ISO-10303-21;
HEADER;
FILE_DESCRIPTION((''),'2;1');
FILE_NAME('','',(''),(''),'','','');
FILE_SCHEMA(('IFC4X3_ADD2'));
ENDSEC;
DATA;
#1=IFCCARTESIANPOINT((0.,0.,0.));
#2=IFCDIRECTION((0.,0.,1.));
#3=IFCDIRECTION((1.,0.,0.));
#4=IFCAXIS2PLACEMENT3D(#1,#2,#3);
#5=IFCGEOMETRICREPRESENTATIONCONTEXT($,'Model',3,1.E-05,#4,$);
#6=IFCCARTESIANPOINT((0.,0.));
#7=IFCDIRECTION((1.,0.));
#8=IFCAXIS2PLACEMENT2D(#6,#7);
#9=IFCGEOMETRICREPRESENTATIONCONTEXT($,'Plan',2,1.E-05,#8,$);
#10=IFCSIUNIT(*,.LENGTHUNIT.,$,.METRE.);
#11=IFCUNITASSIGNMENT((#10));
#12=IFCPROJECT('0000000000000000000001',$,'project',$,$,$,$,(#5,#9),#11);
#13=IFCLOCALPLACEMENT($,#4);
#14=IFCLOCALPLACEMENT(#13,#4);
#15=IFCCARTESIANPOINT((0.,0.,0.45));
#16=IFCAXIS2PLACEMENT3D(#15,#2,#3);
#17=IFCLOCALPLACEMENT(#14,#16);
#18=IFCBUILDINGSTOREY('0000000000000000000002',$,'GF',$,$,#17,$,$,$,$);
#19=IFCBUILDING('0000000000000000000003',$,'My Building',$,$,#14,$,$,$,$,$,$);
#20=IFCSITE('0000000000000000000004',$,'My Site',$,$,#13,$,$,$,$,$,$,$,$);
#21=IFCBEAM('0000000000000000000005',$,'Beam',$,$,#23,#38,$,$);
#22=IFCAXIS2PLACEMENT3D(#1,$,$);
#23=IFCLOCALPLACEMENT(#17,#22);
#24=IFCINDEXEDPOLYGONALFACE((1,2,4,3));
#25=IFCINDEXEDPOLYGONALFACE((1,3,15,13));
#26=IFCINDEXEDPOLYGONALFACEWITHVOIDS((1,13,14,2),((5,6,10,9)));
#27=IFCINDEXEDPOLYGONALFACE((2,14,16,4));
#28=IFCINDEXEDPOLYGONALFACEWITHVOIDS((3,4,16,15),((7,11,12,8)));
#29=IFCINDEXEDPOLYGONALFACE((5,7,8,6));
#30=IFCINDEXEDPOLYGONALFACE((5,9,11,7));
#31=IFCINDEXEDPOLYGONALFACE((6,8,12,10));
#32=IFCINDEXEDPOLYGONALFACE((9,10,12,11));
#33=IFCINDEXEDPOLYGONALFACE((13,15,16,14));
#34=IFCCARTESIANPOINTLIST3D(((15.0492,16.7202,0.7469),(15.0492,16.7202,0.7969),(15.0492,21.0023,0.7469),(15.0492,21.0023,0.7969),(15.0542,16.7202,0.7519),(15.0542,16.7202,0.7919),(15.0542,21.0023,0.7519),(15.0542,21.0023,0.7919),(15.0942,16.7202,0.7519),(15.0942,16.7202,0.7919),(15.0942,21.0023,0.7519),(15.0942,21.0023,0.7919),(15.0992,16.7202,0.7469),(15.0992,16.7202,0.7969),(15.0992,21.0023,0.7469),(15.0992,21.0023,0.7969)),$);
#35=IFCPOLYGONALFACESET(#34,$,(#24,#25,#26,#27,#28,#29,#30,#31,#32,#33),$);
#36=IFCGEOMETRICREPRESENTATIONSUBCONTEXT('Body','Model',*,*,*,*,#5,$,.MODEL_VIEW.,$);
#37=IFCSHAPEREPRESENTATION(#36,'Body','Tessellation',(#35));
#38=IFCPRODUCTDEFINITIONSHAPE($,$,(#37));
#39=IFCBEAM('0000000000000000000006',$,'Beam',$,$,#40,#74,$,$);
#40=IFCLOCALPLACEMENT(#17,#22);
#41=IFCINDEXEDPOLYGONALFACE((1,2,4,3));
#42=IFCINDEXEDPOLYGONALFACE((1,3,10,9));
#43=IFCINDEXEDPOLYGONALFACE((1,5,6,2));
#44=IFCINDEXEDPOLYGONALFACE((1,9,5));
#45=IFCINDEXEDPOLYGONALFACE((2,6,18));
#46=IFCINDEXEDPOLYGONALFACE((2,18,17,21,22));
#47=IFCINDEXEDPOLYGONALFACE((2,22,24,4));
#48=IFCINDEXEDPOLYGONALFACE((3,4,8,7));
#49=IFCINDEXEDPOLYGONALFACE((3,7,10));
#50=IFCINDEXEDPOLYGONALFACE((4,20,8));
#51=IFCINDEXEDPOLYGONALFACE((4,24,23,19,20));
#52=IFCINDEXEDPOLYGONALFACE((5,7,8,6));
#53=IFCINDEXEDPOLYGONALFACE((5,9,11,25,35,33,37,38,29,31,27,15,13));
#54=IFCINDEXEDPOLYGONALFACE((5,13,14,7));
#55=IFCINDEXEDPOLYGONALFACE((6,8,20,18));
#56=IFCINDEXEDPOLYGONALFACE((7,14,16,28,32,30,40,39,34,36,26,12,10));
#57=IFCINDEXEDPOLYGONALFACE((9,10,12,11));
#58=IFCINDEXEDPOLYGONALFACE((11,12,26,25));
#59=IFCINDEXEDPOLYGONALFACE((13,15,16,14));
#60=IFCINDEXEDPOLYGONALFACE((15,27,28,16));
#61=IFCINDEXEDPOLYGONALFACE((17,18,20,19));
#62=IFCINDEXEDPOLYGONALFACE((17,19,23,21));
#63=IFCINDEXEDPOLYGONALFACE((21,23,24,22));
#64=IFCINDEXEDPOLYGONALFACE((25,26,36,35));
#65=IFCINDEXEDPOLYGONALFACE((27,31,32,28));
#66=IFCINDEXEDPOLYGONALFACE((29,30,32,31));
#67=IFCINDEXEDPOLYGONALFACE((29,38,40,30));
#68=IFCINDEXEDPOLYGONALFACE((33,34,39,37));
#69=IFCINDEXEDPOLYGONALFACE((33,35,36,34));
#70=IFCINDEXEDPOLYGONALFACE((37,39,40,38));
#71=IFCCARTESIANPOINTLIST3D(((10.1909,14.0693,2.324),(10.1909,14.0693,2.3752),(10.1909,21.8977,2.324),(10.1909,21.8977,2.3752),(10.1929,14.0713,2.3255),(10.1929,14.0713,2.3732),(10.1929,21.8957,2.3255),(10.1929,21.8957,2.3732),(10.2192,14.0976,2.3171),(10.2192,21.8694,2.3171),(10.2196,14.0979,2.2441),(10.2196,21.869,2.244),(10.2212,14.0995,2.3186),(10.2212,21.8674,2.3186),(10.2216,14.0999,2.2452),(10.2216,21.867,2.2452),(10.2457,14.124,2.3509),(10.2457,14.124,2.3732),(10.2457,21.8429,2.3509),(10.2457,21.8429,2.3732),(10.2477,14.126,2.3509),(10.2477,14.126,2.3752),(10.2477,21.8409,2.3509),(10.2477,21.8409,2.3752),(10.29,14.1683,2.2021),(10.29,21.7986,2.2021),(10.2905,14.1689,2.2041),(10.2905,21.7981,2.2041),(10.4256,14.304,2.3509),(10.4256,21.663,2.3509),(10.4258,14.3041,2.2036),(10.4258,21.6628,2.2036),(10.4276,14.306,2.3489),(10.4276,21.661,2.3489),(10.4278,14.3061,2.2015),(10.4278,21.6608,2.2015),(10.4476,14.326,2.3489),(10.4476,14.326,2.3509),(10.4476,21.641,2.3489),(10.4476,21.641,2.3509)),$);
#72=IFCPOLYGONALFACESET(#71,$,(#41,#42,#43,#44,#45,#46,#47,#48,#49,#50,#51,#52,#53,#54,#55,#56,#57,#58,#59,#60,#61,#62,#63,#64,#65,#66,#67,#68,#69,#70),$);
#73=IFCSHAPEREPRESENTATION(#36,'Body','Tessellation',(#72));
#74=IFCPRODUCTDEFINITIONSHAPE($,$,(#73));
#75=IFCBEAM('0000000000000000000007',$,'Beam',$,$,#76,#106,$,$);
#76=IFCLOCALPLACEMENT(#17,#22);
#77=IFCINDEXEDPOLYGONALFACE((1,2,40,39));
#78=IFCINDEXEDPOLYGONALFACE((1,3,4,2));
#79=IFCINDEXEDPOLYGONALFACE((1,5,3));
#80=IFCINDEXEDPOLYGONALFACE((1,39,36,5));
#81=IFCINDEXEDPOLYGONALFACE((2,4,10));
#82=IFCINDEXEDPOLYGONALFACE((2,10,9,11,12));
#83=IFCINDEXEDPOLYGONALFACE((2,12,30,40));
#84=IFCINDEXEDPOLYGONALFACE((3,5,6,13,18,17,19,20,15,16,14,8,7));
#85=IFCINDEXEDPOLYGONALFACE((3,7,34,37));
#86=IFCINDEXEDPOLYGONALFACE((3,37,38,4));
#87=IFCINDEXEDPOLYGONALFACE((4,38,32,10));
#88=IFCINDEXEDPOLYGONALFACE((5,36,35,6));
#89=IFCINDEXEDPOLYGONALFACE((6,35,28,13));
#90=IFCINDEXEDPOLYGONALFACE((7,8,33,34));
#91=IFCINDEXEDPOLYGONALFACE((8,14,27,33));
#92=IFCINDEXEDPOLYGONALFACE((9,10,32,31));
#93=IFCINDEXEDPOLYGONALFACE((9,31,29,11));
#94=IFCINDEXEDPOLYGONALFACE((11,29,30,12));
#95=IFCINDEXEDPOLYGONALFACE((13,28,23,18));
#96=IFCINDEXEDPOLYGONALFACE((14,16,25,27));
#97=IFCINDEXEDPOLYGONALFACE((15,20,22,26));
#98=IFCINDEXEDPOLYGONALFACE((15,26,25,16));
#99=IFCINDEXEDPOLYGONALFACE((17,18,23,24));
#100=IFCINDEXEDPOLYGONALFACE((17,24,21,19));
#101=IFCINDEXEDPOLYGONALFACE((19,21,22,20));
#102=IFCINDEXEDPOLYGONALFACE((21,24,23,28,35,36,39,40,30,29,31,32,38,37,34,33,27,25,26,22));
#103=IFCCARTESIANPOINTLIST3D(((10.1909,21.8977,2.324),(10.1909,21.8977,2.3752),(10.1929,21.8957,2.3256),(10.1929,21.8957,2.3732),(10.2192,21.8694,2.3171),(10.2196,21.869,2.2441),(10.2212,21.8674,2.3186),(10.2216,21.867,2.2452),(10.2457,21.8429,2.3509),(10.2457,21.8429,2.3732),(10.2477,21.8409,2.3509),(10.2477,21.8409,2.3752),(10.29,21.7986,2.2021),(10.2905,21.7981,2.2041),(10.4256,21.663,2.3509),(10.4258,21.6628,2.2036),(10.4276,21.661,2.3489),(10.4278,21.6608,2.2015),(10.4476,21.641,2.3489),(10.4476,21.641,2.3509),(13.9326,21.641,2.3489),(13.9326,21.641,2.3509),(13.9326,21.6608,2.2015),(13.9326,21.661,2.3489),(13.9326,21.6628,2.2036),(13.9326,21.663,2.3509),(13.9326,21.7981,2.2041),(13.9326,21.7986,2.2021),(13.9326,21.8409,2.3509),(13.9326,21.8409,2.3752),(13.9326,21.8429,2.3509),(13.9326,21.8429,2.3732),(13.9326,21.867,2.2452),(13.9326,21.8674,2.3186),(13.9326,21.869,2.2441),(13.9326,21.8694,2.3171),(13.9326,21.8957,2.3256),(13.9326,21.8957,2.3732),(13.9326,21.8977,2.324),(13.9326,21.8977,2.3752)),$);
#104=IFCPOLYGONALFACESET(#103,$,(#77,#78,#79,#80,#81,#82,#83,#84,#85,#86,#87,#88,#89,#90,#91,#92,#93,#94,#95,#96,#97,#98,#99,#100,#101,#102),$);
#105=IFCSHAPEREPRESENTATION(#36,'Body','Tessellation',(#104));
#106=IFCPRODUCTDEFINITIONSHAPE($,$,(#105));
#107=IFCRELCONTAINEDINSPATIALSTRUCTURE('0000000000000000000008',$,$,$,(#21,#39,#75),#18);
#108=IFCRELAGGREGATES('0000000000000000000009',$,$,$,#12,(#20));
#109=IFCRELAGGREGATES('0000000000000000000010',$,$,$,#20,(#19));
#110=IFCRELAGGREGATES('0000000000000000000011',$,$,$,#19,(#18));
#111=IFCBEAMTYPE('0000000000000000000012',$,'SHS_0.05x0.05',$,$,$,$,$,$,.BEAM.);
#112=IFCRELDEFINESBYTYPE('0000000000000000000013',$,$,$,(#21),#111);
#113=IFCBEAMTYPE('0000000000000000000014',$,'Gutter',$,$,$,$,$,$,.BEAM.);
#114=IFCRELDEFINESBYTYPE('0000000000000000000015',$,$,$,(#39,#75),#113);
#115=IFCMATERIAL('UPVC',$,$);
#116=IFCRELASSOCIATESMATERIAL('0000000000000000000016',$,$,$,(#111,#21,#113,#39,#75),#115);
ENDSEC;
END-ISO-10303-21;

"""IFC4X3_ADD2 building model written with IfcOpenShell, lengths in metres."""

from ifc_helpers import new_model, si_unit, frame, origin_with_axes, origin_2d_with_axis, place, context, subcontext, project, spatial, indexed_curve, hollow_rectangle, outline, extrude, clip, halfspace, material, material_profile, profile_set, profile_usage, type_object, element, save


model = new_model("IFC4X3_ADD2")

# Units and contexts
model_context = context("Model", 3, precision=1e-05, world=origin_with_axes())
plan_context = context("Plan", 2, precision=1e-05, world=origin_2d_with_axis())
body_context_1 = subcontext(model_context, "Body", "Model", "MODEL_VIEW")
ifc_project = project(units=[si_unit("LENGTHUNIT", "METRE")], contexts=[model_context, plan_context])

# Site, building, storey
site_placement = place(None, origin_with_axes())
site = spatial("IfcSite", under=ifc_project, at=site_placement, Name="My Site")
building_placement = place(site_placement, origin_with_axes())
building = spatial("IfcBuilding", under=site, at=building_placement, Name="My Building")
storey_placement = place(building_placement, frame((0.0, 0.0, 0.45), z_axis=(0.0, 0.0, 1.0), x_axis=(1.0, 0.0, 0.0)))
storey = spatial("IfcBuildingStorey", under=building, at=storey_placement, Name="GF")

# Shared definitions
ifc_material_1 = material(Name="UPVC")

# Beams
ifc_material_profile_1 = material_profile(ifc_material_1, hollow_rectangle(XDim=0.05, YDim=0.05, WallThickness=0.005))
ifc_profile_set_1 = profile_set([ifc_material_profile_1])
beam_type_1 = type_object("IfcBeamType", Name="SHS_0.05x0.05", PredefinedType="BEAM", material=ifc_profile_set_1)
ifc_profile_usage_1 = profile_usage(ifc_profile_set_1)
beam_1_placement = place(storey_placement, frame((15.0742, 21.0023, 0.7719), z_axis=(0.0, -1.0, 0.0), x_axis=(1.0, 0.0, 0.0)))
element("IfcBeam", 1, at=beam_1_placement, inside=storey, type_object=beam_type_1, material=ifc_profile_usage_1, Name="Beam", context=body_context_1, shape_type="SweptSolid", body=[
    extrude(hollow_rectangle(XDim=0.05, YDim=0.05, WallThickness=0.005), origin_with_axes(), (0.0, 0.0, 1.0), 4.2821),
])
ifc_material_profile_2 = material_profile(ifc_material_1, outline(indexed_curve([(0.0548, 0.1717), (0.002, 0.1717), (0.002, 0.124), (0.0303, 0.1171), (0.0307, 0.0436), (0.0996, 0.0025), (0.2349, 0.002), (0.2347, 0.1494), (0.2567, 0.1494), (0.2567, 0.1474), (0.2367, 0.1474), (0.2369, 0.0), (0.0991, 0.0005), (0.0287, 0.0425), (0.0283, 0.1155), (0.0, 0.1224), (0.0, 0.1737), (0.0568, 0.1737), (0.0568, 0.1494), (0.0548, 0.1494), (0.0548, 0.1717)])))
ifc_profile_set_2 = profile_set([ifc_material_profile_2])
ifc_profile_usage_2 = profile_usage(ifc_profile_set_2)
beam_type_2 = type_object("IfcBeamType", Name="Gutter", PredefinedType="BEAM", material=ifc_profile_set_2)
beam_2_placement = place(storey_placement, frame((10.1909, 21.8977, 2.2015), z_axis=(0.0, -1.0, 0.0), x_axis=(1.0, 0.0, 0.0)))
element("IfcBeam", 2, at=beam_2_placement, inside=storey, type_object=beam_type_2, material=ifc_profile_usage_2, Name="Beam", context=body_context_1, shape_type="Clipping", body=[
    clip(clip(extrude(outline(indexed_curve([(0.0548, 0.1717), (0.002, 0.1717), (0.002, 0.124), (0.0303, 0.1171), (0.0307, 0.0436), (0.0996, 0.0025), (0.2349, 0.002), (0.2347, 0.1494), (0.2567, 0.1494), (0.2567, 0.1474), (0.2367, 0.1474), (0.2369, 0.0), (0.0991, 0.0005), (0.0287, 0.0425), (0.0283, 0.1155), (0.0, 0.1224), (0.0, 0.1737), (0.0568, 0.1737), (0.0568, 0.1494), (0.0548, 0.1494), (0.0548, 0.1717)])), origin_with_axes(), (0.0, 0.0, 1.0), 7.8284), halfspace(frame((0.0, -2.6516, 7.8284), z_axis=(0.707107, 0.0, 0.707106), x_axis=(0.0, -1.0, 0.0)), False)), halfspace(frame((0.0, -2.6516, 0.0), z_axis=(0.707106, 0.0, -0.707107), x_axis=(0.0, -1.0, 0.0)), False)),
])
ifc_profile_usage_3 = profile_usage(ifc_profile_set_2)
beam_3_placement = place(storey_placement, frame((13.9326, 21.8977, 2.2015), z_axis=(-1.0, 0.000001, 0.0), x_axis=(-0.000001, -1.0, 0.0)))
element("IfcBeam", 3, at=beam_3_placement, inside=storey, type_object=beam_type_2, material=ifc_profile_usage_3, Name="Beam", context=body_context_1, shape_type="Clipping", body=[
    clip(extrude(outline(indexed_curve([(0.0548, 0.1717), (0.002, 0.1717), (0.002, 0.124), (0.0303, 0.1171), (0.0307, 0.0436), (0.0996, 0.0025), (0.2349, 0.002), (0.2347, 0.1494), (0.2567, 0.1494), (0.2567, 0.1474), (0.2367, 0.1474), (0.2369, 0.0), (0.0991, 0.0005), (0.0287, 0.0425), (0.0283, 0.1155), (0.0, 0.1224), (0.0, 0.1737), (0.0568, 0.1737), (0.0568, 0.1494), (0.0548, 0.1494), (0.0548, 0.1717)])), origin_with_axes(), (0.0, 0.0, 1.0), 3.7417), halfspace(frame((0.0, -2.6516, 3.7417), z_axis=(0.707107, 0.0, 0.707106), x_axis=(0.0, -1.0, 0.0)), False)),
])

save(model, "model.ifc")
